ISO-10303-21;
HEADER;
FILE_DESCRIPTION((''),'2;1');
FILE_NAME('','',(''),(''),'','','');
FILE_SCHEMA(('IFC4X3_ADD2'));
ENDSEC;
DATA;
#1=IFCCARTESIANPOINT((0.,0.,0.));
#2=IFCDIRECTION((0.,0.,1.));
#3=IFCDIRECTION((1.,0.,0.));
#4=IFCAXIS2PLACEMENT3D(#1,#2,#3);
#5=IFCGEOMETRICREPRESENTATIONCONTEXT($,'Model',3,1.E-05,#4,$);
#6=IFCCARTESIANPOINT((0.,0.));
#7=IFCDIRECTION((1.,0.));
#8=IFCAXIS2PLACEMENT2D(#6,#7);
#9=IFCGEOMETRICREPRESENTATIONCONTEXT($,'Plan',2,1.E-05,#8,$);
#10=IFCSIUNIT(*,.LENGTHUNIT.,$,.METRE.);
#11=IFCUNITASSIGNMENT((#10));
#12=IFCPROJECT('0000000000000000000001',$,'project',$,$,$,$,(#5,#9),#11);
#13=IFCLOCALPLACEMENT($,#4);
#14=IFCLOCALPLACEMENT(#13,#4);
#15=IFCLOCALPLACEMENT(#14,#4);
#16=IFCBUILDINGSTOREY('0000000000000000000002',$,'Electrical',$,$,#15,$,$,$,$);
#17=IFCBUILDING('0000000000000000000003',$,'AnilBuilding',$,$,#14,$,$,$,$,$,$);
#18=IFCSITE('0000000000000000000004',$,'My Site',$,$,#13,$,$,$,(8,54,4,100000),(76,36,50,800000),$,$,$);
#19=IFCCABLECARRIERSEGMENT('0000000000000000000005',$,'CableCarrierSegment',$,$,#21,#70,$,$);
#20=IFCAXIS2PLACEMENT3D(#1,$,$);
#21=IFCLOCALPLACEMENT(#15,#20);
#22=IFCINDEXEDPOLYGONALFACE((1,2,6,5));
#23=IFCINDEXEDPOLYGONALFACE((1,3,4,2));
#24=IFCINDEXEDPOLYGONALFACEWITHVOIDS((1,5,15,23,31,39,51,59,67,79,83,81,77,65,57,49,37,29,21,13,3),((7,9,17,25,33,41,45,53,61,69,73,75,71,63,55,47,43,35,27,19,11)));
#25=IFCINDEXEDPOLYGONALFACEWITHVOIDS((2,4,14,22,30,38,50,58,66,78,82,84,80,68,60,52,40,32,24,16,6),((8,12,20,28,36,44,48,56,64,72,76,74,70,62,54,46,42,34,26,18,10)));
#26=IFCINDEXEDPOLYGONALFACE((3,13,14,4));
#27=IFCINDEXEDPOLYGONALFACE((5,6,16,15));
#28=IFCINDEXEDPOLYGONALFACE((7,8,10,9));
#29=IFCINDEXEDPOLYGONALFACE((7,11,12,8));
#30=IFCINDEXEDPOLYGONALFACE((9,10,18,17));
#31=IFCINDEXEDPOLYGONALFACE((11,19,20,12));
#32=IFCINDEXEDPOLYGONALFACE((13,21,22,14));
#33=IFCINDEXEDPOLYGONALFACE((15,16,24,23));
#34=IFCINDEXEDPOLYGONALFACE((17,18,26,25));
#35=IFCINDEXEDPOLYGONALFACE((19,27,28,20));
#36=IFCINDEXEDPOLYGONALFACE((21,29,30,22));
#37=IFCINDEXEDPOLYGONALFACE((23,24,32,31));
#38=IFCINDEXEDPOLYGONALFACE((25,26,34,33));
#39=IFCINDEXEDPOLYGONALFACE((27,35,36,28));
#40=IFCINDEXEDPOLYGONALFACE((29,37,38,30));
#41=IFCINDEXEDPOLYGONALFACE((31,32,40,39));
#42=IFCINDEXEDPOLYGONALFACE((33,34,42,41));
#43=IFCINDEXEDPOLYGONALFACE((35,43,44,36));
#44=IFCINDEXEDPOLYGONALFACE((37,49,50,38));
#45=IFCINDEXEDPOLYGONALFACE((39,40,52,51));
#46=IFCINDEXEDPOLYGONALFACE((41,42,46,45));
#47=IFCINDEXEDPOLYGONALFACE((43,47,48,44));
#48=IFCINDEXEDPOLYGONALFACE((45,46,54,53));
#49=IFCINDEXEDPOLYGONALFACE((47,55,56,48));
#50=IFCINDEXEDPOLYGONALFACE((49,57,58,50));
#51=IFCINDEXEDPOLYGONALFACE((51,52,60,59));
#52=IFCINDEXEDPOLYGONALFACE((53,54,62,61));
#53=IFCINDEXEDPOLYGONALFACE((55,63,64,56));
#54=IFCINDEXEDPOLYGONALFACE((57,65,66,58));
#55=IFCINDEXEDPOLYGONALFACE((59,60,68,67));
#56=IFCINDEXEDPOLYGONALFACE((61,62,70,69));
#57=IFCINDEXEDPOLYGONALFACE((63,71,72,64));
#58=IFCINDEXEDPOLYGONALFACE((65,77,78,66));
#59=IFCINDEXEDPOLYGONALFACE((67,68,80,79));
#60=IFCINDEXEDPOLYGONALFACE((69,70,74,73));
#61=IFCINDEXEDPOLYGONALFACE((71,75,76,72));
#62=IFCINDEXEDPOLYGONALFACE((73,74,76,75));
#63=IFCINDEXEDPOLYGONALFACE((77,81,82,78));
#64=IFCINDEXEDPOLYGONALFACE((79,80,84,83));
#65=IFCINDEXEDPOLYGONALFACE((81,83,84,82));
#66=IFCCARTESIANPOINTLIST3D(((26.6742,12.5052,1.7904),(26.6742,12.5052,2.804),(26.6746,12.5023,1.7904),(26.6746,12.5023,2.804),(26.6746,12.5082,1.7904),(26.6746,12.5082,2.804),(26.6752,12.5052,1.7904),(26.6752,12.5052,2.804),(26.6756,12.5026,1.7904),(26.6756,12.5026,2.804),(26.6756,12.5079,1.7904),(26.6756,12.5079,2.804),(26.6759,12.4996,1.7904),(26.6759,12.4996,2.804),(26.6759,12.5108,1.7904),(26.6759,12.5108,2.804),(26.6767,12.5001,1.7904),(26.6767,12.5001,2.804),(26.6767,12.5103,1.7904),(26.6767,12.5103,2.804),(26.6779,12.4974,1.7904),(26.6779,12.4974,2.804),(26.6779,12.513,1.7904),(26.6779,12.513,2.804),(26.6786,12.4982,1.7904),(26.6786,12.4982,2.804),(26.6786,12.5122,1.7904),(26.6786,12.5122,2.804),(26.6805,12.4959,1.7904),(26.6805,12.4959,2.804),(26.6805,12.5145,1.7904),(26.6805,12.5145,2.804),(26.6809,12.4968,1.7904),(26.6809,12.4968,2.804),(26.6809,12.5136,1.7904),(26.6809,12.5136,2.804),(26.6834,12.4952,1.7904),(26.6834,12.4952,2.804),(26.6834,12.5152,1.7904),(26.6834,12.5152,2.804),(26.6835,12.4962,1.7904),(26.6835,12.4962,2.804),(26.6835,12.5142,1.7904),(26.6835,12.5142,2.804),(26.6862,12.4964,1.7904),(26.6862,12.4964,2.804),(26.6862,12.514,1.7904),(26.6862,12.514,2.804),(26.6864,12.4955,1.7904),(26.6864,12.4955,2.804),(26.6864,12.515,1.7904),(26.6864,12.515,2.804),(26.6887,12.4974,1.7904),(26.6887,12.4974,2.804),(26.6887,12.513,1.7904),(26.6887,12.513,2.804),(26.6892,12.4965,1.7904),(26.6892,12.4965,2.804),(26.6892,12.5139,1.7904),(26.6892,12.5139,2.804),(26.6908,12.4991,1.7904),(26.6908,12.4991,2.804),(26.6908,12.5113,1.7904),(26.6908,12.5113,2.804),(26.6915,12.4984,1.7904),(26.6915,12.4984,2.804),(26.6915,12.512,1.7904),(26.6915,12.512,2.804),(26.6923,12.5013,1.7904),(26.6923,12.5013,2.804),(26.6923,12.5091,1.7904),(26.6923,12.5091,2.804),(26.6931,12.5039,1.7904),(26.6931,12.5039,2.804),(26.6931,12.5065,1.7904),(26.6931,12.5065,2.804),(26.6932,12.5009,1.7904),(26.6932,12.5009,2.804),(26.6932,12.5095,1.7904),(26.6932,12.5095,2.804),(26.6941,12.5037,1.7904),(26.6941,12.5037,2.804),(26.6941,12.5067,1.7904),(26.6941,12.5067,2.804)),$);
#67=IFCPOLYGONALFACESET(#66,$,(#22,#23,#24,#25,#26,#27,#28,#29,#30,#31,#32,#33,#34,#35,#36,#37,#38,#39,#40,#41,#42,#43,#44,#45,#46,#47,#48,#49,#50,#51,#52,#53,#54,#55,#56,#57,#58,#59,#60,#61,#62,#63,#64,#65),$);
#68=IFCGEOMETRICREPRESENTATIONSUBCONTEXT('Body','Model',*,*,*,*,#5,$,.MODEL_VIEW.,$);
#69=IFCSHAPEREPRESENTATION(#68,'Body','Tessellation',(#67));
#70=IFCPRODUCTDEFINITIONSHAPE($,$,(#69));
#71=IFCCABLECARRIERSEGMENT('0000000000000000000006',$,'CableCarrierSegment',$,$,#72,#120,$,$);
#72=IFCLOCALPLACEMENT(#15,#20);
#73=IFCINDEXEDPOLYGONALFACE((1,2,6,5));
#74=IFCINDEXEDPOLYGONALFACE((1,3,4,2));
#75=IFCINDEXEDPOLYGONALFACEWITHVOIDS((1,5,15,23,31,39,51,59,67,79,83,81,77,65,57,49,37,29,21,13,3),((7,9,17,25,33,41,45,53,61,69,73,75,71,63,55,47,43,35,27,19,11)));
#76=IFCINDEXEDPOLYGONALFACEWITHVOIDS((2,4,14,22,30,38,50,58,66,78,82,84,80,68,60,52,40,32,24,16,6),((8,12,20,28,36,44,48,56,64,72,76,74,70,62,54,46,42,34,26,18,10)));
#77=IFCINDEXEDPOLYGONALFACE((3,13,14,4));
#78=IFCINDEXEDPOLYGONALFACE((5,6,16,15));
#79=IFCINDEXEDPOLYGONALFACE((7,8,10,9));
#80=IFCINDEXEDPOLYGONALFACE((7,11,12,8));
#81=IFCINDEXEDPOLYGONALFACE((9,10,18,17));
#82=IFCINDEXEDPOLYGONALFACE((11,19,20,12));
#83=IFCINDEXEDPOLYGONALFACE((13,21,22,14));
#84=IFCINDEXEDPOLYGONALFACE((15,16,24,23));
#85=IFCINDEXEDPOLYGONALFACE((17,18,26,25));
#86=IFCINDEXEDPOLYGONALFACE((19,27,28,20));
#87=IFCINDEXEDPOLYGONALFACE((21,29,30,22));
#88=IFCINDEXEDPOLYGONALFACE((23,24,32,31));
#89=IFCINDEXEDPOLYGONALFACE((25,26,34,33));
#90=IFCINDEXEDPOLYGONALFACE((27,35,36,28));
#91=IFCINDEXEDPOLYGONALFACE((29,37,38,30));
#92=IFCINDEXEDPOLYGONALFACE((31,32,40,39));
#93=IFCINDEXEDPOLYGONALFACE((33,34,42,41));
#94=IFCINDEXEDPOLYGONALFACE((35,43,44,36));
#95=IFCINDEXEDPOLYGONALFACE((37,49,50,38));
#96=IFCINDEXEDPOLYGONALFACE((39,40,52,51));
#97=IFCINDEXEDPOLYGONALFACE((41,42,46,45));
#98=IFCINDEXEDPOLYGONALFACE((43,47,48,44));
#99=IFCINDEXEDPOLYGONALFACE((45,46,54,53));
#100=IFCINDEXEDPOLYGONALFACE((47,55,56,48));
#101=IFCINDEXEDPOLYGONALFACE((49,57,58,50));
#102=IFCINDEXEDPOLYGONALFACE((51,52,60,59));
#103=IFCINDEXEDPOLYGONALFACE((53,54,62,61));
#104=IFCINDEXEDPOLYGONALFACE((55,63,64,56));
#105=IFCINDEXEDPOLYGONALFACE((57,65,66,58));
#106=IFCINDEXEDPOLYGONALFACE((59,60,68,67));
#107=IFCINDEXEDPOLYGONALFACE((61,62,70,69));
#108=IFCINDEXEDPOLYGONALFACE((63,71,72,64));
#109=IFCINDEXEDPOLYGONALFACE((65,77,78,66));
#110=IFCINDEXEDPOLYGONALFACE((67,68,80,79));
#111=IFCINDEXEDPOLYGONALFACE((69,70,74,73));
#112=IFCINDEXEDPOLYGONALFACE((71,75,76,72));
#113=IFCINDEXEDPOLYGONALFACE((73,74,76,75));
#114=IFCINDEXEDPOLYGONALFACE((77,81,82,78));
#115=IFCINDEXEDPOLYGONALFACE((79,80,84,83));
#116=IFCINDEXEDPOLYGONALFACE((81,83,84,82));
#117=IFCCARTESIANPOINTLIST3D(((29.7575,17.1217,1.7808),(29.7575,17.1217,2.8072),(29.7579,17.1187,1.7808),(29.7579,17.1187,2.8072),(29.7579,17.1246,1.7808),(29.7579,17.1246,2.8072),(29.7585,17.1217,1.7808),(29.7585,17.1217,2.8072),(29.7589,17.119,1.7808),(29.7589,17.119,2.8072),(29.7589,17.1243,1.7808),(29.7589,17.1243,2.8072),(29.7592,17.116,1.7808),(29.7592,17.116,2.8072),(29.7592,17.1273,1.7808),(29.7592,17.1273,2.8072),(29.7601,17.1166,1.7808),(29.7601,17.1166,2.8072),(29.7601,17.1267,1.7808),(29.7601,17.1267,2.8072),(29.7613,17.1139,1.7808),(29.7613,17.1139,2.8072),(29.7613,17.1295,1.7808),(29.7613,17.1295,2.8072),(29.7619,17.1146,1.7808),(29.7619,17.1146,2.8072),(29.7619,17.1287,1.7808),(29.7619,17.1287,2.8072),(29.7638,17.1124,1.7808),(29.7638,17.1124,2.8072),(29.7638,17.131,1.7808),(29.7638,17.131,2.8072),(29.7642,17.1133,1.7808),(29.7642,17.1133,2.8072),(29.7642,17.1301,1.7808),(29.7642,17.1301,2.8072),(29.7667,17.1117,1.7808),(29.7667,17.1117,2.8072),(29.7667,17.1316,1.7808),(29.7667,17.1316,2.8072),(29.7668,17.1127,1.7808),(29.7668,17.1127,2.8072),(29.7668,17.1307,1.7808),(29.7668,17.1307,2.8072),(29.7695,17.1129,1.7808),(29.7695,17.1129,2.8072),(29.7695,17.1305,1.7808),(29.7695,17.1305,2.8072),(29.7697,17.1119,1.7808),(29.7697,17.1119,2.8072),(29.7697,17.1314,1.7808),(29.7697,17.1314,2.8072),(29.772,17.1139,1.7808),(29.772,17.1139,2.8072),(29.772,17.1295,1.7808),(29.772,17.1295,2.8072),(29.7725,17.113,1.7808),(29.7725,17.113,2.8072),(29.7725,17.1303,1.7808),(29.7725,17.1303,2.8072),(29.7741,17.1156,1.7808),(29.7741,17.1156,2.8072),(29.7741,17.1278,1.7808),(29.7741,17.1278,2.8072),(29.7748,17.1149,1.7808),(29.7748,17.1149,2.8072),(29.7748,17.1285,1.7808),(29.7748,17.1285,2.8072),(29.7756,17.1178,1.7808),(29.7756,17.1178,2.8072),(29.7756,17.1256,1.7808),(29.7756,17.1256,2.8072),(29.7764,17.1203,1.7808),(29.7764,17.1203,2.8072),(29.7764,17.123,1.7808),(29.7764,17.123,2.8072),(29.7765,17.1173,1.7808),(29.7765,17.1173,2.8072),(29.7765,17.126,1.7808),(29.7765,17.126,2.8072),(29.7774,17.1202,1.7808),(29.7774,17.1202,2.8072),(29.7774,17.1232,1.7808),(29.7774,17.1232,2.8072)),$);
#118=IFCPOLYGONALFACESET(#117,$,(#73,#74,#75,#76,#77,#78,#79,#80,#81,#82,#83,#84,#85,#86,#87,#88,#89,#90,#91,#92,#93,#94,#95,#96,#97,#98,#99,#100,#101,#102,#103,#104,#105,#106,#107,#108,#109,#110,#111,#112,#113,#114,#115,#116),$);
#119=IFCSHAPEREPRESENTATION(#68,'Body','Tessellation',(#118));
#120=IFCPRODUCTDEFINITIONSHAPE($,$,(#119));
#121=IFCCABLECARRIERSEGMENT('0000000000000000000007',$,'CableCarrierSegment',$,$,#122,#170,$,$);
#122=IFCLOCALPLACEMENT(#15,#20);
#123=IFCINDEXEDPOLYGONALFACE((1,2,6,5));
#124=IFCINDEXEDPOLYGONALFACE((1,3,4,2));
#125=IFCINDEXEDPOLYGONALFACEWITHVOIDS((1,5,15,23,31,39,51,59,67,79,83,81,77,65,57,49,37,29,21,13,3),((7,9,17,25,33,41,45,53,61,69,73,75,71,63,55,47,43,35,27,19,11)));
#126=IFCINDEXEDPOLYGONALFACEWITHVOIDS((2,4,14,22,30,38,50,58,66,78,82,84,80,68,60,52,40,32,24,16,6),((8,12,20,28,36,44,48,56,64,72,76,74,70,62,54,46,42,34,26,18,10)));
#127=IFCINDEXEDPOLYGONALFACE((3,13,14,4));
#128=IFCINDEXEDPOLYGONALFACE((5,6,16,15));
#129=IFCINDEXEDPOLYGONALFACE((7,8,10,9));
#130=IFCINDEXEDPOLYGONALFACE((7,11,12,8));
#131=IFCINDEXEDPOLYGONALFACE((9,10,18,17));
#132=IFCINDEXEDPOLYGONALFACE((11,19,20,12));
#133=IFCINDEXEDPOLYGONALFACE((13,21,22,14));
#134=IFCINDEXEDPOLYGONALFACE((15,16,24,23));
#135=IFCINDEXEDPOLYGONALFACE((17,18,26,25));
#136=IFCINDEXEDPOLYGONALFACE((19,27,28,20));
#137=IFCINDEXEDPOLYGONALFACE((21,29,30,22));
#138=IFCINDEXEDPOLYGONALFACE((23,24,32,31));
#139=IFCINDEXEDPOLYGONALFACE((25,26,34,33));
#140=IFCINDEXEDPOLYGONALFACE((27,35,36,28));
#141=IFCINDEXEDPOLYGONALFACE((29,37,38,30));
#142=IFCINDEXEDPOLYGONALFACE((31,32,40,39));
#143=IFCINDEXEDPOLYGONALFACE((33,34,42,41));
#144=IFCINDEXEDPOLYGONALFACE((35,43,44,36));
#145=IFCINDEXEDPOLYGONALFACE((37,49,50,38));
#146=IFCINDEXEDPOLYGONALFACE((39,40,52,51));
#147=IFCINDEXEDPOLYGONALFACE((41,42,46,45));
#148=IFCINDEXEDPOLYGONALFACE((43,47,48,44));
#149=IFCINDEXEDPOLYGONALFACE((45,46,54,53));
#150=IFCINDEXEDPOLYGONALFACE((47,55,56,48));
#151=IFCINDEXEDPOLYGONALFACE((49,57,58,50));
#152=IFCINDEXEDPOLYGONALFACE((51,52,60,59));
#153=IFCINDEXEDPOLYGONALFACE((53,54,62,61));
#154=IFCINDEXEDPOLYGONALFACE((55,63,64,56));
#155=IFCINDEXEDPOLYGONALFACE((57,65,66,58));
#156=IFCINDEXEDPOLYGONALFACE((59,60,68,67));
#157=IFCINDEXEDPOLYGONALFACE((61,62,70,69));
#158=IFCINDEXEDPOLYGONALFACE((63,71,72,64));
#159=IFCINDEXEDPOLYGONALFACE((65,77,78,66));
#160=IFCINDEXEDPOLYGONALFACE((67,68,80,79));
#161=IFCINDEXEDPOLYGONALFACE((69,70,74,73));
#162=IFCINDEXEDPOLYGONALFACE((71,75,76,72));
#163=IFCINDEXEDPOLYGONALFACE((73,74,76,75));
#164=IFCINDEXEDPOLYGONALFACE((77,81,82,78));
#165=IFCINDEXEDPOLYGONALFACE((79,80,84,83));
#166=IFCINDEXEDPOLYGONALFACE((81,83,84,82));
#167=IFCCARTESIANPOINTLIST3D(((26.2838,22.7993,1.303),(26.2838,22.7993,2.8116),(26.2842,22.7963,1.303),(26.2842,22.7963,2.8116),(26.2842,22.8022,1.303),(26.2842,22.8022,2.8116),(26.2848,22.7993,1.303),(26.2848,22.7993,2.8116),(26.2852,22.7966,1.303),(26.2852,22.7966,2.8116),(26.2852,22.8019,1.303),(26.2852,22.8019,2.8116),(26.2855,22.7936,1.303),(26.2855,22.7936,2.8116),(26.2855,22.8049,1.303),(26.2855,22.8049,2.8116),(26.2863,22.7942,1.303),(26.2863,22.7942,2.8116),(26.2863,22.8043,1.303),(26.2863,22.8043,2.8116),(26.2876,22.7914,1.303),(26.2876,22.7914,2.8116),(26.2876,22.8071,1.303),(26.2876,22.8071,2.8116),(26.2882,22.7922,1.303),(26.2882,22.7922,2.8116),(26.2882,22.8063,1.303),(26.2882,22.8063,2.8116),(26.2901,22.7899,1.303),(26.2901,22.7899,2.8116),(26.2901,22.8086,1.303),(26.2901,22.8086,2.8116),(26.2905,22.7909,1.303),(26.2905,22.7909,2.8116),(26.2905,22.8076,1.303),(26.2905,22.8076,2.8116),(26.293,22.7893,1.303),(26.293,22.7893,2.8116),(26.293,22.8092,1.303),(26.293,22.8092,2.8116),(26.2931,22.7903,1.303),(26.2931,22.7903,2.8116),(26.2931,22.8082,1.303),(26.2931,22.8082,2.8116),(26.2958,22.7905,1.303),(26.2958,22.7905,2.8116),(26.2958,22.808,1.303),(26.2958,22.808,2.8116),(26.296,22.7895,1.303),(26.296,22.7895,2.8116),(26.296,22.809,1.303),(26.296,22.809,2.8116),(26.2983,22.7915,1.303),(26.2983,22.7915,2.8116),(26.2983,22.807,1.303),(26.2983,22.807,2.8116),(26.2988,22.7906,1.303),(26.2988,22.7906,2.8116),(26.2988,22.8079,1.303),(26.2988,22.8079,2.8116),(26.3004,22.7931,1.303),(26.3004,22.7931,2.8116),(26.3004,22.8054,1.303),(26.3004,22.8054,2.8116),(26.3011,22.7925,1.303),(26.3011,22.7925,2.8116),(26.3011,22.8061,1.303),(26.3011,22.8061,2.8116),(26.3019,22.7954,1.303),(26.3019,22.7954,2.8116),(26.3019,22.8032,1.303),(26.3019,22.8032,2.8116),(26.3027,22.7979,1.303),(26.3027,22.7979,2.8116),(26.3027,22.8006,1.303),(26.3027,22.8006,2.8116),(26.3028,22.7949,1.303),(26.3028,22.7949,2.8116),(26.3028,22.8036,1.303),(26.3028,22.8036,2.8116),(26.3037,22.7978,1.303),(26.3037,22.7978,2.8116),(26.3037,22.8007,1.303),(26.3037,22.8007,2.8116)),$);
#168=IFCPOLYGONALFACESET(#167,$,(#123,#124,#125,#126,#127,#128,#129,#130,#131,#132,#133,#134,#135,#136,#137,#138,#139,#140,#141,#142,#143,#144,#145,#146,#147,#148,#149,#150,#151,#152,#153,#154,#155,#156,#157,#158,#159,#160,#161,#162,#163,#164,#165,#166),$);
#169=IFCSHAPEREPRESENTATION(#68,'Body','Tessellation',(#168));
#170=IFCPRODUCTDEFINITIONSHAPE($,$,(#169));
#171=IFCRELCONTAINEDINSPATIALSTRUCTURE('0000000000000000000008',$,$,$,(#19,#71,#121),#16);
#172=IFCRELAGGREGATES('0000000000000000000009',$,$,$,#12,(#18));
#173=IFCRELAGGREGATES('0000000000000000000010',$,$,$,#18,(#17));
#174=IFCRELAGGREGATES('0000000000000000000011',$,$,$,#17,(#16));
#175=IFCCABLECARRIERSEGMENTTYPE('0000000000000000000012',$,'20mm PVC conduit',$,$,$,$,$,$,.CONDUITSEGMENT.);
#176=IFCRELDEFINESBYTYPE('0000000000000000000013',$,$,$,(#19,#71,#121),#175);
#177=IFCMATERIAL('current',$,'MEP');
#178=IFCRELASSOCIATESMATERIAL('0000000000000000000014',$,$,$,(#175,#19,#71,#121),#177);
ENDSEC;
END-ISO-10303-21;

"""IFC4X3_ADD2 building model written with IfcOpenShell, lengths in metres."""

from ifc_helpers import new_model, si_unit, frame, origin_with_axes, origin_2d_with_axis, place, context, subcontext, project, spatial, hollow_circle, extrude, material, material_profile, profile_set, profile_usage, type_object, element, save


model = new_model("IFC4X3_ADD2")

# Units and contexts
model_context = context("Model", 3, precision=1e-05, world=origin_with_axes())
plan_context = context("Plan", 2, precision=1e-05, world=origin_2d_with_axis())
body_context = subcontext(model_context, "Body", "Model", "MODEL_VIEW")
ifc_project = project(units=[si_unit("LENGTHUNIT", "METRE")], contexts=[model_context, plan_context])

# Site, building, storey
site_placement = place(None, origin_with_axes())
site = spatial("IfcSite", under=ifc_project, at=site_placement, Name="My Site", RefLatitude=(8, 54, 4, 100000), RefLongitude=(76, 36, 50, 800000))
building_placement = place(site_placement, origin_with_axes())
building = spatial("IfcBuilding", under=site, at=building_placement, Name="AnilBuilding")
storey_placement = place(building_placement, origin_with_axes())
storey = spatial("IfcBuildingStorey", under=building, at=storey_placement, Name="Electrical")

# Cable carrier segments
ifc_material = material(Name="current", Category="MEP")
ifc_material_profile_1 = material_profile(ifc_material, hollow_circle(Radius=0.01, WallThickness=0.001))
ifc_profile_set_1 = profile_set([ifc_material_profile_1], Name="current")
ifc_material_profile_2 = material_profile(ifc_material, hollow_circle(Radius=0.01, WallThickness=0.001))
ifc_profile_set_2 = profile_set([ifc_material_profile_2], Name="current")
cable_carrier_segment_type = type_object("IfcCableCarrierSegmentType", Name="20mm PVC conduit", PredefinedType="CONDUITSEGMENT", material=ifc_profile_set_2)
ifc_profile_usage_1 = profile_usage(ifc_profile_set_1, cardinal=5)
cable_carrier_segment_1_placement = place(storey_placement, frame((26.6842, 12.5052, 1.7904), z_axis=(0.0, 0.0, 1.0), x_axis=(-1.0, 0.0, 0.0)))
element("IfcCableCarrierSegment", 1, at=cable_carrier_segment_1_placement, inside=storey, type_object=cable_carrier_segment_type, material=ifc_profile_usage_1, Name="CableCarrierSegment", context=body_context, shape_type="SweptSolid", body=[
    extrude(hollow_circle(Radius=0.01, WallThickness=0.001), origin_with_axes(), (0.0, 0.0, 1.0), 1.0136),
])
ifc_profile_usage_2 = profile_usage(ifc_profile_set_1, cardinal=5)
cable_carrier_segment_2_placement = place(storey_placement, frame((29.7675, 17.1217, 1.7808), z_axis=(0.0, 0.0, 1.0), x_axis=(-1.0, 0.0, 0.0)))
element("IfcCableCarrierSegment", 2, at=cable_carrier_segment_2_placement, inside=storey, type_object=cable_carrier_segment_type, material=ifc_profile_usage_2, Name="CableCarrierSegment", context=body_context, shape_type="SweptSolid", body=[
    extrude(hollow_circle(Radius=0.01, WallThickness=0.001), origin_with_axes(), (0.0, 0.0, 1.0), 1.0264),
])
ifc_profile_usage_3 = profile_usage(ifc_profile_set_1, cardinal=5)
cable_carrier_segment_3_placement = place(storey_placement, frame((26.2938, 22.7993, 1.303), z_axis=(0.0, 0.0, 1.0), x_axis=(-1.0, 0.0, 0.0)))
element("IfcCableCarrierSegment", 3, at=cable_carrier_segment_3_placement, inside=storey, type_object=cable_carrier_segment_type, material=ifc_profile_usage_3, Name="CableCarrierSegment", context=body_context, shape_type="SweptSolid", body=[
    extrude(hollow_circle(Radius=0.01, WallThickness=0.001), origin_with_axes(), (0.0, 0.0, 1.0), 1.5087),
])

save(model, "model.ifc")
